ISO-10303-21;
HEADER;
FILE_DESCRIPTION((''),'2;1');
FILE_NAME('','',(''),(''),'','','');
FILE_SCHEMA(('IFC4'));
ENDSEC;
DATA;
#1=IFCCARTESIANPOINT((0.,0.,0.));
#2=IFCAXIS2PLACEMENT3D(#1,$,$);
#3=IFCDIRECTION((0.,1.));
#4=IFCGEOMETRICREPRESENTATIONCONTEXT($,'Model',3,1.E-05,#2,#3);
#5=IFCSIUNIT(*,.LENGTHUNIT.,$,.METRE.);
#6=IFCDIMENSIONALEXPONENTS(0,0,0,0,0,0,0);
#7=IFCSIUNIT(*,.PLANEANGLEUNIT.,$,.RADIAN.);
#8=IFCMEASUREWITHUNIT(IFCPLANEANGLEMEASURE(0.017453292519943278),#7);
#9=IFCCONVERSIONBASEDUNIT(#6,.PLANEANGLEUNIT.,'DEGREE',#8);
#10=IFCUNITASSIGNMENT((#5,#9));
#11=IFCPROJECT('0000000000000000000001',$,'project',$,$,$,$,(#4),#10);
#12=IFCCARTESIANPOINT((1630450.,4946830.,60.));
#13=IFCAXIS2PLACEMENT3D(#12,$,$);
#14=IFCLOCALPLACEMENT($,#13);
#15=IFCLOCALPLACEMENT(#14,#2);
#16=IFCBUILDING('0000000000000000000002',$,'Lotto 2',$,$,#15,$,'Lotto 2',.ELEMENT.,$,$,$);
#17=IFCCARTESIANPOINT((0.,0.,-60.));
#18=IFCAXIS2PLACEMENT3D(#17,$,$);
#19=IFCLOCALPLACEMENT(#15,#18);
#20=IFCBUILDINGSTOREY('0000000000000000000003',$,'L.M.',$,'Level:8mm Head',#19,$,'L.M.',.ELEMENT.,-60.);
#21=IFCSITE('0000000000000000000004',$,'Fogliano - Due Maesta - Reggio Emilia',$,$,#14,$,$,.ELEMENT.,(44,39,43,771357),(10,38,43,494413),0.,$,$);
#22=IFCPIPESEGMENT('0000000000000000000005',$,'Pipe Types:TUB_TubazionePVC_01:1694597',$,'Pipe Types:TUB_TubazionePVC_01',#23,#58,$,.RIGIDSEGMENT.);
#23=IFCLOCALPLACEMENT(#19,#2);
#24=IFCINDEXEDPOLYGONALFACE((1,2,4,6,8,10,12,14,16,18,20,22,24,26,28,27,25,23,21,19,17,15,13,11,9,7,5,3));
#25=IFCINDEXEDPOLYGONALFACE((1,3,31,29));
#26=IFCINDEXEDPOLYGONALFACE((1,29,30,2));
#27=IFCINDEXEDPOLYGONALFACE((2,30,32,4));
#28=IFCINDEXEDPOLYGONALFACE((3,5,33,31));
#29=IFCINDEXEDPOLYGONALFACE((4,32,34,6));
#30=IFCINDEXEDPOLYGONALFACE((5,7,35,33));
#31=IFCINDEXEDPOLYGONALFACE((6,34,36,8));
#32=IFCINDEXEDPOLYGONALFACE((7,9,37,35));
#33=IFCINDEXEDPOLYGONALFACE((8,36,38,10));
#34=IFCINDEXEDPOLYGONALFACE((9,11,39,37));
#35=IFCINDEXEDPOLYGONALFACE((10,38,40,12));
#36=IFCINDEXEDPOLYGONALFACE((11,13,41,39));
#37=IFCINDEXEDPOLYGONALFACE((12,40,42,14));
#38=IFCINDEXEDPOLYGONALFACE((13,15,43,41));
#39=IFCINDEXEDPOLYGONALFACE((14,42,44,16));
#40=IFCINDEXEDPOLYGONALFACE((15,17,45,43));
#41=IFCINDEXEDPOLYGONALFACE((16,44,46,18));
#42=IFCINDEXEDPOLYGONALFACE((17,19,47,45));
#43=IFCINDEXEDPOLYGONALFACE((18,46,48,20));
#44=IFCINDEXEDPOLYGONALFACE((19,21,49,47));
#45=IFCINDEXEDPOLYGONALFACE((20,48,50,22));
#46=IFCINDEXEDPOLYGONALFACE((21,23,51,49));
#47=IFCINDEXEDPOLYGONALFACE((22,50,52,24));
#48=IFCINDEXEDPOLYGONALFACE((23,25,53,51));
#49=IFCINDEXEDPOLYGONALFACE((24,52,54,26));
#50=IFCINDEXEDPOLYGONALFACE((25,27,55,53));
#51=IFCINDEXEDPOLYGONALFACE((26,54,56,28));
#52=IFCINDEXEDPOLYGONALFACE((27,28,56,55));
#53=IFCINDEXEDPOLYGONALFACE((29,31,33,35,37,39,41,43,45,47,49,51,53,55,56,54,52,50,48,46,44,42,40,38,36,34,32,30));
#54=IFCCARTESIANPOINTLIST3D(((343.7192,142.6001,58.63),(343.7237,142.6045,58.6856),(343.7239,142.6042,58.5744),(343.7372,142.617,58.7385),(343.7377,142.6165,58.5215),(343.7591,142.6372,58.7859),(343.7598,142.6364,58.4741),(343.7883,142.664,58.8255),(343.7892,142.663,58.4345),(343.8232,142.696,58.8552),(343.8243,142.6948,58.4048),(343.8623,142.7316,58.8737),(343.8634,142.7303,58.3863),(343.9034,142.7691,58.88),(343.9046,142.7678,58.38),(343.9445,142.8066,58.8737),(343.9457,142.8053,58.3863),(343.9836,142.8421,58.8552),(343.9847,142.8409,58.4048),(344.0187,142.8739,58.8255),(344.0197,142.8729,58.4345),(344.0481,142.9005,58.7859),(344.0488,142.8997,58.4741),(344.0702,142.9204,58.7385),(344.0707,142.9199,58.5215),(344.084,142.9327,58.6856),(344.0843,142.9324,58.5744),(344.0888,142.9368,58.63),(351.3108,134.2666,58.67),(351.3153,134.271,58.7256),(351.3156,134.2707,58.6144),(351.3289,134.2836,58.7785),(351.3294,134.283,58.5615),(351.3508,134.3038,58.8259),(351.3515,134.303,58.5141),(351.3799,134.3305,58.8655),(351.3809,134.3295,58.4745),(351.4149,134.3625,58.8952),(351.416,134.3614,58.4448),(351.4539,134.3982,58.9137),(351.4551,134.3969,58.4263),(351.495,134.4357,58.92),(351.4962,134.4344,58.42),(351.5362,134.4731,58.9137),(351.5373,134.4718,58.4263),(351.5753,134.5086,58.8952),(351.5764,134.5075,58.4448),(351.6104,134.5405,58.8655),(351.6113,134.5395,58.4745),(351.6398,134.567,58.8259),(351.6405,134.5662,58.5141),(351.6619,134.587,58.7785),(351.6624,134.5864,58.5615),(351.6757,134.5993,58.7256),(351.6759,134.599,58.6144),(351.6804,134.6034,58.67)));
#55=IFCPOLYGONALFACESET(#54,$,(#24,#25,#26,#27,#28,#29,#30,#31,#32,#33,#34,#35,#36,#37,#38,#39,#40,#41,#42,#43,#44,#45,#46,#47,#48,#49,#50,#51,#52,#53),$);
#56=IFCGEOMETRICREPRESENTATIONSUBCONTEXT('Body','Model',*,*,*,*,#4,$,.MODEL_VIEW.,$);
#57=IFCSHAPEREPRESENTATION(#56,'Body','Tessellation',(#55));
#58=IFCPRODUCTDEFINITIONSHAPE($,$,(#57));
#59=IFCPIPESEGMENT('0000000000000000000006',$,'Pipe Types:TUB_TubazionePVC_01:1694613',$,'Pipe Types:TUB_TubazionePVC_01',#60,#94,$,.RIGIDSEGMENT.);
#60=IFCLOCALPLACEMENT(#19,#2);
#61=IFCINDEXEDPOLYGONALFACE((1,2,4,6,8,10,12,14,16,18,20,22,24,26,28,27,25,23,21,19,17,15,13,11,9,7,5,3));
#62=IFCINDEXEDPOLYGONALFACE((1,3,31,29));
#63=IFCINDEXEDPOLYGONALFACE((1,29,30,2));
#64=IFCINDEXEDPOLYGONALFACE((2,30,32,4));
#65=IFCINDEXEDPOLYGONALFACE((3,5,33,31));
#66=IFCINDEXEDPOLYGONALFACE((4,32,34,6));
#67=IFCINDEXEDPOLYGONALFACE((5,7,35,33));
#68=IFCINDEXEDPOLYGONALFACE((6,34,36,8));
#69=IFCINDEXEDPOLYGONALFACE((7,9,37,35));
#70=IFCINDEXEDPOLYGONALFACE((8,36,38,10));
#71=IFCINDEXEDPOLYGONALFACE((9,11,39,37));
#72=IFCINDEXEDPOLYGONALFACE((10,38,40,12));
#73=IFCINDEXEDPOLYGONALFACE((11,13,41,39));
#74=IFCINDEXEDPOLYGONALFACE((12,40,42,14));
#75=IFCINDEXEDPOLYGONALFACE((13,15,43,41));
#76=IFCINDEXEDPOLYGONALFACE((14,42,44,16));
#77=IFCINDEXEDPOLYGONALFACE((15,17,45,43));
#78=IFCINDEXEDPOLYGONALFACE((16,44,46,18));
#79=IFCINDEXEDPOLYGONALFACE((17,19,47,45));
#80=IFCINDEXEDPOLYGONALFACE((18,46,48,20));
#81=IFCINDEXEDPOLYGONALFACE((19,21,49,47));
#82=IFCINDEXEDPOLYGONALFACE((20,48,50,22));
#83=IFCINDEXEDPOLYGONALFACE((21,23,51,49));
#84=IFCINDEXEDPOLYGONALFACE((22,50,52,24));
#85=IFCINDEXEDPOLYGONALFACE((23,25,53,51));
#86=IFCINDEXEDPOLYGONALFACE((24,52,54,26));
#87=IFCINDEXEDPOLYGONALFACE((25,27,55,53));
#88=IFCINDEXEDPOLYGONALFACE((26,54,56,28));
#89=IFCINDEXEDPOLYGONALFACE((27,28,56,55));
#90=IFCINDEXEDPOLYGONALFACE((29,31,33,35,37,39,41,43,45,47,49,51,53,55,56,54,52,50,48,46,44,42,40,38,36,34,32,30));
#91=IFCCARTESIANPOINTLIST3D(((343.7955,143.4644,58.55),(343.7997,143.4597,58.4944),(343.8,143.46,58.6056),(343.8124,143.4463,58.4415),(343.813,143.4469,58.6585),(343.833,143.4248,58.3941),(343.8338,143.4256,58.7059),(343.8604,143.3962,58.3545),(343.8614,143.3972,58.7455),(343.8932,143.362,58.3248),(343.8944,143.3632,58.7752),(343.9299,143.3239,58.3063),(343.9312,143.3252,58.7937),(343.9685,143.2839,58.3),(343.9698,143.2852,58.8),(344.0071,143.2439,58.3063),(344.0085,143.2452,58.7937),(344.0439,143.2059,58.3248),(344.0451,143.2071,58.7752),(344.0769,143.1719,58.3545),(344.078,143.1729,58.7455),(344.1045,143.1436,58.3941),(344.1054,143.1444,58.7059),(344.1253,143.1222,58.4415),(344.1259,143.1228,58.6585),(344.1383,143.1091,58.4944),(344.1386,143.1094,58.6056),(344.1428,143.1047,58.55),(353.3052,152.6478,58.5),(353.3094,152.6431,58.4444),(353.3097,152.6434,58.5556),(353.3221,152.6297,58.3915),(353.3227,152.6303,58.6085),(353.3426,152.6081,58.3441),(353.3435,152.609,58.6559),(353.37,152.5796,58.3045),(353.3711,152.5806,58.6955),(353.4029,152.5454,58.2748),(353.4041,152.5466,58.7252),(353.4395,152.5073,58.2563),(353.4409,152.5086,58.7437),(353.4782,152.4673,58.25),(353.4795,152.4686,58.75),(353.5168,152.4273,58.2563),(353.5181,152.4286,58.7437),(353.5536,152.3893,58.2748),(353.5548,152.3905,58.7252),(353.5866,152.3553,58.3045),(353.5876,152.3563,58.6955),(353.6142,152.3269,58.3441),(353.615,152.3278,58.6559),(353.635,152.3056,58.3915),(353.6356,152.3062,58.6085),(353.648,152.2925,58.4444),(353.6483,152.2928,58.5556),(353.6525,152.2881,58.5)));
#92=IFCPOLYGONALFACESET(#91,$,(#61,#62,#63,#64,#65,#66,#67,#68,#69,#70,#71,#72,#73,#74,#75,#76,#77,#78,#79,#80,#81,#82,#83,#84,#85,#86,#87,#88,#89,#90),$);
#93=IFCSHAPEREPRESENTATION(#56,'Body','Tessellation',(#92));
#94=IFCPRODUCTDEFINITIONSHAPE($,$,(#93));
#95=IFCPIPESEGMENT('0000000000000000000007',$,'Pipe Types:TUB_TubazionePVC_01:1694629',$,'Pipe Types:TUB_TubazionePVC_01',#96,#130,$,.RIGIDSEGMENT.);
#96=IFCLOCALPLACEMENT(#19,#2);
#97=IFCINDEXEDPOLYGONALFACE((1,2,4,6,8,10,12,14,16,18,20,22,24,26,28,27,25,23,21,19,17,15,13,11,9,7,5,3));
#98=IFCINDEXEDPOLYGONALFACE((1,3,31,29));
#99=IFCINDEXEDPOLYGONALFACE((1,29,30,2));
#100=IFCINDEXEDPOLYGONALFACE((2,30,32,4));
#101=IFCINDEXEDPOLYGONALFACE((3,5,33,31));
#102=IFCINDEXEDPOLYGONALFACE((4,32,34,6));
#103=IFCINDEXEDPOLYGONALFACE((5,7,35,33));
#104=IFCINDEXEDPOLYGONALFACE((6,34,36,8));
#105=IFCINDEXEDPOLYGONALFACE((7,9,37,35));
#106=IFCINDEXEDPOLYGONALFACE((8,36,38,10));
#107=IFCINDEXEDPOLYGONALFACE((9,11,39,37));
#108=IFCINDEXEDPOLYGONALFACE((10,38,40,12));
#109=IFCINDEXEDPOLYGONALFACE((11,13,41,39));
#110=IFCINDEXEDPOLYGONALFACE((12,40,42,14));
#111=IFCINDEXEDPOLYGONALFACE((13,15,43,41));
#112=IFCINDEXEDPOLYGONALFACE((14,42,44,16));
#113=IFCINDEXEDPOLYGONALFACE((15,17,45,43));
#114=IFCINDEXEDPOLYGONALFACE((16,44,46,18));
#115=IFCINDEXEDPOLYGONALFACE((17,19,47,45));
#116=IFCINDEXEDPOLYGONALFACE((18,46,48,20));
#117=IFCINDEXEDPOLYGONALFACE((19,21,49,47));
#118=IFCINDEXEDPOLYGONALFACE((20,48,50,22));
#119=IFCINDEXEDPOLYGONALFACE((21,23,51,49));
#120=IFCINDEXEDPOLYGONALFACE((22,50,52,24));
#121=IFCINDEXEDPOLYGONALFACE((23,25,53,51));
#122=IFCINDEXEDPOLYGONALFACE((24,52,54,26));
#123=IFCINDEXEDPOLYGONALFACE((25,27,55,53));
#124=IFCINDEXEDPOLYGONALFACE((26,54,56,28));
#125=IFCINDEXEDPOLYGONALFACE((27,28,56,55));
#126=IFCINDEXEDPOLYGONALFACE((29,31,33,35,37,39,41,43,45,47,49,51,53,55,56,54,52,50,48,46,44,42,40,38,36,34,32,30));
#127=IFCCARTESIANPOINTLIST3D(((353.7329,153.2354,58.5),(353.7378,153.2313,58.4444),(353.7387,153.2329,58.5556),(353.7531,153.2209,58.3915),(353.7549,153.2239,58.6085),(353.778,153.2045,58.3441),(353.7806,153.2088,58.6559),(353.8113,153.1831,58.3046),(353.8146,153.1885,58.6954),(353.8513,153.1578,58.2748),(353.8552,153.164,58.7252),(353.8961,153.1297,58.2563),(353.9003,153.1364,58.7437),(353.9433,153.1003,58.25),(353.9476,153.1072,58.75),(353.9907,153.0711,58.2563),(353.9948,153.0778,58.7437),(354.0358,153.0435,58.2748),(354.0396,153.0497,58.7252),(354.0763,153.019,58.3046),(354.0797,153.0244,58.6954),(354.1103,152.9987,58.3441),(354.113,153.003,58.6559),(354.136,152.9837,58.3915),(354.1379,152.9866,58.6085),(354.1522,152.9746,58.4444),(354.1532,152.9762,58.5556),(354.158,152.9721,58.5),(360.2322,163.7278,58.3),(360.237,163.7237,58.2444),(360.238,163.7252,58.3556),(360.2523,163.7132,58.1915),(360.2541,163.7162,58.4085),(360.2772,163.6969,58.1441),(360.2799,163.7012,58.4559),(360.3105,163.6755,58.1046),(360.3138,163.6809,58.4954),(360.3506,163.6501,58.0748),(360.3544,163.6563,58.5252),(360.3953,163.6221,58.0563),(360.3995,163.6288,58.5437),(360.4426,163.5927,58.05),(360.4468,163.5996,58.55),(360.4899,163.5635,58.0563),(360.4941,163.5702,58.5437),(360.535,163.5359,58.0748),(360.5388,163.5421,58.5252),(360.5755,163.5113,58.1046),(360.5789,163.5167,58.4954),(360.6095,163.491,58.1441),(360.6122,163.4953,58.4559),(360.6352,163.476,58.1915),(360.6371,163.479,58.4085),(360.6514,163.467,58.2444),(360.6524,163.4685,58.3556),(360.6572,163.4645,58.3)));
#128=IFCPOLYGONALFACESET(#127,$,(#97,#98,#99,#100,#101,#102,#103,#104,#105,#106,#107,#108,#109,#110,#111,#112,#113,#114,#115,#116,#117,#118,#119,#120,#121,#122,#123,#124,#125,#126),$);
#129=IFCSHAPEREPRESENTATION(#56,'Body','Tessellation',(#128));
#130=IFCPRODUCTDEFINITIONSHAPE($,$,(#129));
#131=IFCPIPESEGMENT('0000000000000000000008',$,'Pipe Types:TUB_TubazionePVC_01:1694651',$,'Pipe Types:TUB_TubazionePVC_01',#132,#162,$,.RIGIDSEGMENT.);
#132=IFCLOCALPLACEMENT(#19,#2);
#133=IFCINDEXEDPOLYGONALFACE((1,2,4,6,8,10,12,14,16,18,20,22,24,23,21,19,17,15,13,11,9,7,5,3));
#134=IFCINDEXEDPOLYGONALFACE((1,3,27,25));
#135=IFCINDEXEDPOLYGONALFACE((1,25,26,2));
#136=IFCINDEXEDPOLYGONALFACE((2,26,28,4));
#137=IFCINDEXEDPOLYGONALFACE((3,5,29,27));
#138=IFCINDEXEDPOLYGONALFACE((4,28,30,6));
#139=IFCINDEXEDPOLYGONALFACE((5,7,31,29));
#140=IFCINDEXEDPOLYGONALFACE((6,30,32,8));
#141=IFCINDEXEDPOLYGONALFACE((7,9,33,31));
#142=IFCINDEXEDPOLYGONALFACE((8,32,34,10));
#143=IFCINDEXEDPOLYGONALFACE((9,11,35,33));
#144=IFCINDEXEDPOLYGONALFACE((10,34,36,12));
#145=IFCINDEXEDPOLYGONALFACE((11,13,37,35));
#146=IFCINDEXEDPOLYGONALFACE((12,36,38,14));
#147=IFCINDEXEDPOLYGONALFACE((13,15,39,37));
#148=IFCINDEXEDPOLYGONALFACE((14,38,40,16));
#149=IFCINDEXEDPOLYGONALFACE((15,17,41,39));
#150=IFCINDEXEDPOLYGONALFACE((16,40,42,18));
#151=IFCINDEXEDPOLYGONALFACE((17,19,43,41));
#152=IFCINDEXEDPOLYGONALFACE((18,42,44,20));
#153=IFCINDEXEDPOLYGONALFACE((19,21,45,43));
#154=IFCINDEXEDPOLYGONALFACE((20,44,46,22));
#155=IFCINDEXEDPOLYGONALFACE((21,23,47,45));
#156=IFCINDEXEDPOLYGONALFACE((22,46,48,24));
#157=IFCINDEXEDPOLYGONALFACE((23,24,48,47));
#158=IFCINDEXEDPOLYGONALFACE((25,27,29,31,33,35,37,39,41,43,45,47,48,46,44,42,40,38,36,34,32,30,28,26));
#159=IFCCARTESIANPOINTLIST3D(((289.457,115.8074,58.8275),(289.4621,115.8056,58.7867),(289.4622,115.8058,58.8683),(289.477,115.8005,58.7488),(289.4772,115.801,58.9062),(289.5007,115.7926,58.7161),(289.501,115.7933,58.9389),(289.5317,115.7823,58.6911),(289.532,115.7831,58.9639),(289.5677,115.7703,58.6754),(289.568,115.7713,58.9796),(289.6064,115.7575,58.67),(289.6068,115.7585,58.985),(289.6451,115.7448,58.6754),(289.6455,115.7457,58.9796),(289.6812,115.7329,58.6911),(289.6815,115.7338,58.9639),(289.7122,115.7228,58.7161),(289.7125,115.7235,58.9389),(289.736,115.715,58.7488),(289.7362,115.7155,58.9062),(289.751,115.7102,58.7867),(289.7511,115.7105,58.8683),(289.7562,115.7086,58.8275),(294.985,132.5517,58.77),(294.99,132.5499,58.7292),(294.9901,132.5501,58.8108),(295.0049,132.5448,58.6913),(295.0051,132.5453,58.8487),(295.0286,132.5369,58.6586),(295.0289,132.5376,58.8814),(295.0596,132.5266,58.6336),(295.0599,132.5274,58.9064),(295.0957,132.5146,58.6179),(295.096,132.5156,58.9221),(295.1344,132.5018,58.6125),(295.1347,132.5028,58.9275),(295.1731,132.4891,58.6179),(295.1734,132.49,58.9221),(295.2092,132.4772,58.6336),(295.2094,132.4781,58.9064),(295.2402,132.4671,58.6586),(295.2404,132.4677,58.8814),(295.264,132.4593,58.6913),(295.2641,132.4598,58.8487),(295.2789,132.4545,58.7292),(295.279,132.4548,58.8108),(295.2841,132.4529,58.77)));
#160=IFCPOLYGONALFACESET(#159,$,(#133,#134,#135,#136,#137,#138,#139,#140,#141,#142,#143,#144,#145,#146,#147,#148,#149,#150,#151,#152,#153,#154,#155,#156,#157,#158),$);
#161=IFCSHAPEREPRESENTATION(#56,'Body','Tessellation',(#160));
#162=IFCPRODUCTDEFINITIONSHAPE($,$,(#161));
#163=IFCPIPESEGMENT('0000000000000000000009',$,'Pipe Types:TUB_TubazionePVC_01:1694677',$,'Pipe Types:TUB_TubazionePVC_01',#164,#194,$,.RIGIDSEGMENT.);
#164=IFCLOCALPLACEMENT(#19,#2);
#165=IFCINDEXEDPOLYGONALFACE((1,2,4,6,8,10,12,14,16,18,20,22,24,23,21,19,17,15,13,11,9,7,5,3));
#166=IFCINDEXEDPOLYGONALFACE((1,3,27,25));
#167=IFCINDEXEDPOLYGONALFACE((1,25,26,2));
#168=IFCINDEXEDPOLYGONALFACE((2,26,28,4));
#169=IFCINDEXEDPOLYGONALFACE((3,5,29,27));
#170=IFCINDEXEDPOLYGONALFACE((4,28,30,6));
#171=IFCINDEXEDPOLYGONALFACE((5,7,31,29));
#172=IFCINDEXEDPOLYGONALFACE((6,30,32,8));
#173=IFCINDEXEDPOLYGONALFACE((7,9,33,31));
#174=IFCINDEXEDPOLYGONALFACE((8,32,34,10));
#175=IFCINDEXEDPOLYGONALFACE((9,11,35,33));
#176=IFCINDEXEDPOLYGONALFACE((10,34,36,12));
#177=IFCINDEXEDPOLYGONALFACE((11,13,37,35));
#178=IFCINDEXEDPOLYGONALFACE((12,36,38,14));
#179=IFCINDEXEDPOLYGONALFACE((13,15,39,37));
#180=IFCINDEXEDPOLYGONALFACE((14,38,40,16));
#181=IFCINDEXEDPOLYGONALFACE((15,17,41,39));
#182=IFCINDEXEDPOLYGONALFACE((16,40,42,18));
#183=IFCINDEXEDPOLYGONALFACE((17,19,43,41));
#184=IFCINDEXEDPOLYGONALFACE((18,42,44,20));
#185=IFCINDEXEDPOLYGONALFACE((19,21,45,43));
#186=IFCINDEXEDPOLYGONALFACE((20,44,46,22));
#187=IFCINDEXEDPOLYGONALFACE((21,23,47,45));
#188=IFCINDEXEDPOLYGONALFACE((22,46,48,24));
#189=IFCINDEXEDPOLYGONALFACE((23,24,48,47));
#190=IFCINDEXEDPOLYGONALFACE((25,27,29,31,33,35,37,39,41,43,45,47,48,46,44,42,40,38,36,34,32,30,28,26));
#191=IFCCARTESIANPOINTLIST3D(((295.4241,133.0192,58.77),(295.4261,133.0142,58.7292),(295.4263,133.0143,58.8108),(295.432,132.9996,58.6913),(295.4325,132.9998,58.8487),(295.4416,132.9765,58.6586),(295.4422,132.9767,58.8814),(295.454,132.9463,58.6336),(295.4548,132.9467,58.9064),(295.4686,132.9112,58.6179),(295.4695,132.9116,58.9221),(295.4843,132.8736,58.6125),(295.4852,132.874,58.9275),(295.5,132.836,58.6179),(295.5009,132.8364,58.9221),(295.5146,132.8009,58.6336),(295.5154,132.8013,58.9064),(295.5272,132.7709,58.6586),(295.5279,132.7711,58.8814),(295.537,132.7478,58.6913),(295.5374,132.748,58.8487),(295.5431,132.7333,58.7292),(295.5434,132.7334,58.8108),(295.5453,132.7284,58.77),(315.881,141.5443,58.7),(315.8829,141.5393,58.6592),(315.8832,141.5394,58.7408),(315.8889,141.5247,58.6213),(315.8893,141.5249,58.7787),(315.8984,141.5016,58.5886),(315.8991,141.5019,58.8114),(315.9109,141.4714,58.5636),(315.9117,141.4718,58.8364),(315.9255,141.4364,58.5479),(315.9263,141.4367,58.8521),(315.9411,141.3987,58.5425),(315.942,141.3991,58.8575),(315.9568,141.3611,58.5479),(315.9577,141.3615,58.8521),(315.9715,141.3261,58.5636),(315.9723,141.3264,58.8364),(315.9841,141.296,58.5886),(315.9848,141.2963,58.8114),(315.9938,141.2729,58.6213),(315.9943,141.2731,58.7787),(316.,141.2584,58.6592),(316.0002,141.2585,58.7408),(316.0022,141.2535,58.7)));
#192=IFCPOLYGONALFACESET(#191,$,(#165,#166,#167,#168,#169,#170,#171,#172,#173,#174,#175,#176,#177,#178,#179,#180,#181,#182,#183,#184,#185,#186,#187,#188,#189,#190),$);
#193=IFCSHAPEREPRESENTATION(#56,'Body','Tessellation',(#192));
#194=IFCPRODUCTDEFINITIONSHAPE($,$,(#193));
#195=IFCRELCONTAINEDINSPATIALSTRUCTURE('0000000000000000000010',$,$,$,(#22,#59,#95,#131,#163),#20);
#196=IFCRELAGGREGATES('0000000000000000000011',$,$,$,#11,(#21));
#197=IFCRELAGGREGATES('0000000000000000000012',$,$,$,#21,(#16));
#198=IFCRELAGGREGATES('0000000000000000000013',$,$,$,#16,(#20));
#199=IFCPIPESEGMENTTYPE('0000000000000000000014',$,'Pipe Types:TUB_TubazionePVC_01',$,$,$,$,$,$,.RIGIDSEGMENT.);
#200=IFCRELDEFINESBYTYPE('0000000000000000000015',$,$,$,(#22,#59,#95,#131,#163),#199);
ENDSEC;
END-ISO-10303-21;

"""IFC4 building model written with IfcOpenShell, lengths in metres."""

from ifc_helpers import new_model, entity, si_unit, converted_unit, direction, frame, origin, place, context, subcontext, project, spatial, arc, indexed_curve, outline, extrude, type_object, element, save


model = new_model("IFC4")

# Units and contexts
model_context = context("Model", 3, precision=1e-05, world=origin(), true_north=direction((0.0, 1.0)))
body_context = subcontext(model_context, "Body", "Model", "MODEL_VIEW")
ifc_project = project(units=[si_unit("LENGTHUNIT", "METRE"), converted_unit("PLANEANGLEUNIT", "DEGREE", entity("IfcPlaneAngleMeasure", 0.017453292519943278), si_unit("PLANEANGLEUNIT", "RADIAN"), dimensions=[0, 0, 0, 0, 0, 0, 0])], contexts=[model_context])

# Site, building, storey
site_placement = place(None, frame((1630450.0, 4946830.0, 60.0)))
site = spatial("IfcSite", under=ifc_project, at=site_placement, Name="Fogliano - Due Maesta - Reggio Emilia", CompositionType="ELEMENT", RefLatitude=(44, 39, 43, 771357), RefLongitude=(10, 38, 43, 494413), RefElevation=0.0)
building_placement = place(site_placement, origin())
building = spatial("IfcBuilding", under=site, at=building_placement, Name="Lotto 2", LongName="Lotto 2", CompositionType="ELEMENT")
storey_placement = place(building_placement, frame((0.0, 0.0, -60.0)))
storey = spatial("IfcBuildingStorey", under=building, at=storey_placement, Name="L.M.", ObjectType="Level:8mm Head", LongName="L.M.", CompositionType="ELEMENT", Elevation=-60.0)

# Pipe segments
pipe_segment_type = type_object("IfcPipeSegmentType", Name="Pipe Types:TUB_TubazionePVC_01", PredefinedType="RIGIDSEGMENT")
pipe_segment_1_placement = place(storey_placement, origin())
element("IfcPipeSegment", 1, at=pipe_segment_1_placement, inside=storey, type_object=pipe_segment_type, Name="Pipe Types:TUB_TubazionePVC_01:1694597", ObjectType="Pipe Types:TUB_TubazionePVC_01", PredefinedType="RIGIDSEGMENT", context=body_context, shape_type="SweptSolid", body=[
    extrude(outline(indexed_curve([(0.25, 0.0), (0.1768, 0.1768), (0.0, 0.25), (-0.1768, 0.1768), (-0.25, 0.0), (-0.1768, -0.1768), (0.0, -0.25), (0.1768, -0.1768)], segments=[arc(1, 2, 3), arc(3, 4, 5), arc(5, 6, 7), arc(7, 8, 1)], self_intersect=False)), frame((343.904, 142.7685, 58.63), z_axis=(0.673436, -0.739237, 0.003548), x_axis=(0.739241, 0.673441, 0.0)), (0.0, 0.0, 1.0), 11.273),
])
pipe_segment_2_placement = place(storey_placement, origin())
element("IfcPipeSegment", 2, at=pipe_segment_2_placement, inside=storey, type_object=pipe_segment_type, Name="Pipe Types:TUB_TubazionePVC_01:1694613", ObjectType="Pipe Types:TUB_TubazionePVC_01", PredefinedType="RIGIDSEGMENT", context=body_context, shape_type="SweptSolid", body=[
    extrude(outline(indexed_curve([(0.25, 0.0), (0.1768, 0.1768), (0.0, 0.25), (-0.1768, 0.1768), (-0.25, 0.0), (-0.1768, -0.1768), (0.0, -0.25), (0.1768, -0.1768)], segments=[arc(1, 2, 3), arc(3, 4, 5), arc(5, 6, 7), arc(7, 8, 1)], self_intersect=False)), frame((353.4788, 152.4679, 58.5), z_axis=(-0.719335, -0.694653, 0.003782), x_axis=(0.694658, -0.71934, 0.0)), (0.0, 0.0, 1.0), 13.2201),
])
pipe_segment_3_placement = place(storey_placement, origin())
element("IfcPipeSegment", 3, at=pipe_segment_3_placement, inside=storey, type_object=pipe_segment_type, Name="Pipe Types:TUB_TubazionePVC_01:1694629", ObjectType="Pipe Types:TUB_TubazionePVC_01", PredefinedType="RIGIDSEGMENT", context=body_context, shape_type="SweptSolid", body=[
    extrude(outline(indexed_curve([(0.25, 0.0), (0.1768, 0.1768), (0.0, 0.25), (-0.1768, 0.1768), (-0.25, 0.0), (-0.1768, -0.1768), (0.0, -0.25), (0.1768, -0.1768)], segments=[arc(1, 2, 3), arc(3, 4, 5), arc(5, 6, 7), arc(7, 8, 1)], self_intersect=False)), frame((360.4447, 163.5961, 58.3), z_axis=(-0.526517, -0.85001, 0.016202), x_axis=(0.850122, -0.526586, 0.0)), (0.0, 0.0, 1.0), 12.3438),
])
pipe_segment_4_placement = place(storey_placement, origin())
element("IfcPipeSegment", 4, at=pipe_segment_4_placement, inside=storey, type_object=pipe_segment_type, Name="Pipe Types:TUB_TubazionePVC_01:1694651", ObjectType="Pipe Types:TUB_TubazionePVC_01", PredefinedType="RIGIDSEGMENT", context=body_context, shape_type="SweptSolid", body=[
    extrude(outline(indexed_curve([(0.1575, 0.0), (0.1114, 0.1114), (0.0, 0.1575), (-0.1114, 0.1114), (-0.1575, 0.0), (-0.1114, -0.1114), (0.0, -0.1575), (0.1114, -0.1114)], segments=[arc(1, 2, 3), arc(3, 4, 5), arc(5, 6, 7), arc(7, 8, 1)], self_intersect=False)), frame((295.1345, 132.5023, 58.77), z_axis=(-0.313494, -0.949585, 0.003261), x_axis=(0.94959, -0.313495, 0.0)), (0.0, 0.0, 1.0), 17.6333),
])
pipe_segment_5_placement = place(storey_placement, origin())
element("IfcPipeSegment", 5, at=pipe_segment_5_placement, inside=storey, type_object=pipe_segment_type, Name="Pipe Types:TUB_TubazionePVC_01:1694677", ObjectType="Pipe Types:TUB_TubazionePVC_01", PredefinedType="RIGIDSEGMENT", context=body_context, shape_type="SweptSolid", body=[
    extrude(outline(indexed_curve([(0.1575, 0.0), (0.1114, 0.1114), (0.0, 0.1575), (-0.1114, 0.1114), (-0.1575, 0.0), (-0.1114, -0.1114), (0.0, -0.1575), (0.1114, -0.1114)], segments=[arc(1, 2, 3), arc(3, 4, 5), arc(5, 6, 7), arc(7, 8, 1)], self_intersect=False)), frame((315.9416, 141.3989, 58.7), z_axis=(-0.923049, -0.384668, 0.003159), x_axis=(0.38467, -0.923054, 0.0)), (0.0, 0.0, 1.0), 22.1623),
])

save(model, "model.ifc")
